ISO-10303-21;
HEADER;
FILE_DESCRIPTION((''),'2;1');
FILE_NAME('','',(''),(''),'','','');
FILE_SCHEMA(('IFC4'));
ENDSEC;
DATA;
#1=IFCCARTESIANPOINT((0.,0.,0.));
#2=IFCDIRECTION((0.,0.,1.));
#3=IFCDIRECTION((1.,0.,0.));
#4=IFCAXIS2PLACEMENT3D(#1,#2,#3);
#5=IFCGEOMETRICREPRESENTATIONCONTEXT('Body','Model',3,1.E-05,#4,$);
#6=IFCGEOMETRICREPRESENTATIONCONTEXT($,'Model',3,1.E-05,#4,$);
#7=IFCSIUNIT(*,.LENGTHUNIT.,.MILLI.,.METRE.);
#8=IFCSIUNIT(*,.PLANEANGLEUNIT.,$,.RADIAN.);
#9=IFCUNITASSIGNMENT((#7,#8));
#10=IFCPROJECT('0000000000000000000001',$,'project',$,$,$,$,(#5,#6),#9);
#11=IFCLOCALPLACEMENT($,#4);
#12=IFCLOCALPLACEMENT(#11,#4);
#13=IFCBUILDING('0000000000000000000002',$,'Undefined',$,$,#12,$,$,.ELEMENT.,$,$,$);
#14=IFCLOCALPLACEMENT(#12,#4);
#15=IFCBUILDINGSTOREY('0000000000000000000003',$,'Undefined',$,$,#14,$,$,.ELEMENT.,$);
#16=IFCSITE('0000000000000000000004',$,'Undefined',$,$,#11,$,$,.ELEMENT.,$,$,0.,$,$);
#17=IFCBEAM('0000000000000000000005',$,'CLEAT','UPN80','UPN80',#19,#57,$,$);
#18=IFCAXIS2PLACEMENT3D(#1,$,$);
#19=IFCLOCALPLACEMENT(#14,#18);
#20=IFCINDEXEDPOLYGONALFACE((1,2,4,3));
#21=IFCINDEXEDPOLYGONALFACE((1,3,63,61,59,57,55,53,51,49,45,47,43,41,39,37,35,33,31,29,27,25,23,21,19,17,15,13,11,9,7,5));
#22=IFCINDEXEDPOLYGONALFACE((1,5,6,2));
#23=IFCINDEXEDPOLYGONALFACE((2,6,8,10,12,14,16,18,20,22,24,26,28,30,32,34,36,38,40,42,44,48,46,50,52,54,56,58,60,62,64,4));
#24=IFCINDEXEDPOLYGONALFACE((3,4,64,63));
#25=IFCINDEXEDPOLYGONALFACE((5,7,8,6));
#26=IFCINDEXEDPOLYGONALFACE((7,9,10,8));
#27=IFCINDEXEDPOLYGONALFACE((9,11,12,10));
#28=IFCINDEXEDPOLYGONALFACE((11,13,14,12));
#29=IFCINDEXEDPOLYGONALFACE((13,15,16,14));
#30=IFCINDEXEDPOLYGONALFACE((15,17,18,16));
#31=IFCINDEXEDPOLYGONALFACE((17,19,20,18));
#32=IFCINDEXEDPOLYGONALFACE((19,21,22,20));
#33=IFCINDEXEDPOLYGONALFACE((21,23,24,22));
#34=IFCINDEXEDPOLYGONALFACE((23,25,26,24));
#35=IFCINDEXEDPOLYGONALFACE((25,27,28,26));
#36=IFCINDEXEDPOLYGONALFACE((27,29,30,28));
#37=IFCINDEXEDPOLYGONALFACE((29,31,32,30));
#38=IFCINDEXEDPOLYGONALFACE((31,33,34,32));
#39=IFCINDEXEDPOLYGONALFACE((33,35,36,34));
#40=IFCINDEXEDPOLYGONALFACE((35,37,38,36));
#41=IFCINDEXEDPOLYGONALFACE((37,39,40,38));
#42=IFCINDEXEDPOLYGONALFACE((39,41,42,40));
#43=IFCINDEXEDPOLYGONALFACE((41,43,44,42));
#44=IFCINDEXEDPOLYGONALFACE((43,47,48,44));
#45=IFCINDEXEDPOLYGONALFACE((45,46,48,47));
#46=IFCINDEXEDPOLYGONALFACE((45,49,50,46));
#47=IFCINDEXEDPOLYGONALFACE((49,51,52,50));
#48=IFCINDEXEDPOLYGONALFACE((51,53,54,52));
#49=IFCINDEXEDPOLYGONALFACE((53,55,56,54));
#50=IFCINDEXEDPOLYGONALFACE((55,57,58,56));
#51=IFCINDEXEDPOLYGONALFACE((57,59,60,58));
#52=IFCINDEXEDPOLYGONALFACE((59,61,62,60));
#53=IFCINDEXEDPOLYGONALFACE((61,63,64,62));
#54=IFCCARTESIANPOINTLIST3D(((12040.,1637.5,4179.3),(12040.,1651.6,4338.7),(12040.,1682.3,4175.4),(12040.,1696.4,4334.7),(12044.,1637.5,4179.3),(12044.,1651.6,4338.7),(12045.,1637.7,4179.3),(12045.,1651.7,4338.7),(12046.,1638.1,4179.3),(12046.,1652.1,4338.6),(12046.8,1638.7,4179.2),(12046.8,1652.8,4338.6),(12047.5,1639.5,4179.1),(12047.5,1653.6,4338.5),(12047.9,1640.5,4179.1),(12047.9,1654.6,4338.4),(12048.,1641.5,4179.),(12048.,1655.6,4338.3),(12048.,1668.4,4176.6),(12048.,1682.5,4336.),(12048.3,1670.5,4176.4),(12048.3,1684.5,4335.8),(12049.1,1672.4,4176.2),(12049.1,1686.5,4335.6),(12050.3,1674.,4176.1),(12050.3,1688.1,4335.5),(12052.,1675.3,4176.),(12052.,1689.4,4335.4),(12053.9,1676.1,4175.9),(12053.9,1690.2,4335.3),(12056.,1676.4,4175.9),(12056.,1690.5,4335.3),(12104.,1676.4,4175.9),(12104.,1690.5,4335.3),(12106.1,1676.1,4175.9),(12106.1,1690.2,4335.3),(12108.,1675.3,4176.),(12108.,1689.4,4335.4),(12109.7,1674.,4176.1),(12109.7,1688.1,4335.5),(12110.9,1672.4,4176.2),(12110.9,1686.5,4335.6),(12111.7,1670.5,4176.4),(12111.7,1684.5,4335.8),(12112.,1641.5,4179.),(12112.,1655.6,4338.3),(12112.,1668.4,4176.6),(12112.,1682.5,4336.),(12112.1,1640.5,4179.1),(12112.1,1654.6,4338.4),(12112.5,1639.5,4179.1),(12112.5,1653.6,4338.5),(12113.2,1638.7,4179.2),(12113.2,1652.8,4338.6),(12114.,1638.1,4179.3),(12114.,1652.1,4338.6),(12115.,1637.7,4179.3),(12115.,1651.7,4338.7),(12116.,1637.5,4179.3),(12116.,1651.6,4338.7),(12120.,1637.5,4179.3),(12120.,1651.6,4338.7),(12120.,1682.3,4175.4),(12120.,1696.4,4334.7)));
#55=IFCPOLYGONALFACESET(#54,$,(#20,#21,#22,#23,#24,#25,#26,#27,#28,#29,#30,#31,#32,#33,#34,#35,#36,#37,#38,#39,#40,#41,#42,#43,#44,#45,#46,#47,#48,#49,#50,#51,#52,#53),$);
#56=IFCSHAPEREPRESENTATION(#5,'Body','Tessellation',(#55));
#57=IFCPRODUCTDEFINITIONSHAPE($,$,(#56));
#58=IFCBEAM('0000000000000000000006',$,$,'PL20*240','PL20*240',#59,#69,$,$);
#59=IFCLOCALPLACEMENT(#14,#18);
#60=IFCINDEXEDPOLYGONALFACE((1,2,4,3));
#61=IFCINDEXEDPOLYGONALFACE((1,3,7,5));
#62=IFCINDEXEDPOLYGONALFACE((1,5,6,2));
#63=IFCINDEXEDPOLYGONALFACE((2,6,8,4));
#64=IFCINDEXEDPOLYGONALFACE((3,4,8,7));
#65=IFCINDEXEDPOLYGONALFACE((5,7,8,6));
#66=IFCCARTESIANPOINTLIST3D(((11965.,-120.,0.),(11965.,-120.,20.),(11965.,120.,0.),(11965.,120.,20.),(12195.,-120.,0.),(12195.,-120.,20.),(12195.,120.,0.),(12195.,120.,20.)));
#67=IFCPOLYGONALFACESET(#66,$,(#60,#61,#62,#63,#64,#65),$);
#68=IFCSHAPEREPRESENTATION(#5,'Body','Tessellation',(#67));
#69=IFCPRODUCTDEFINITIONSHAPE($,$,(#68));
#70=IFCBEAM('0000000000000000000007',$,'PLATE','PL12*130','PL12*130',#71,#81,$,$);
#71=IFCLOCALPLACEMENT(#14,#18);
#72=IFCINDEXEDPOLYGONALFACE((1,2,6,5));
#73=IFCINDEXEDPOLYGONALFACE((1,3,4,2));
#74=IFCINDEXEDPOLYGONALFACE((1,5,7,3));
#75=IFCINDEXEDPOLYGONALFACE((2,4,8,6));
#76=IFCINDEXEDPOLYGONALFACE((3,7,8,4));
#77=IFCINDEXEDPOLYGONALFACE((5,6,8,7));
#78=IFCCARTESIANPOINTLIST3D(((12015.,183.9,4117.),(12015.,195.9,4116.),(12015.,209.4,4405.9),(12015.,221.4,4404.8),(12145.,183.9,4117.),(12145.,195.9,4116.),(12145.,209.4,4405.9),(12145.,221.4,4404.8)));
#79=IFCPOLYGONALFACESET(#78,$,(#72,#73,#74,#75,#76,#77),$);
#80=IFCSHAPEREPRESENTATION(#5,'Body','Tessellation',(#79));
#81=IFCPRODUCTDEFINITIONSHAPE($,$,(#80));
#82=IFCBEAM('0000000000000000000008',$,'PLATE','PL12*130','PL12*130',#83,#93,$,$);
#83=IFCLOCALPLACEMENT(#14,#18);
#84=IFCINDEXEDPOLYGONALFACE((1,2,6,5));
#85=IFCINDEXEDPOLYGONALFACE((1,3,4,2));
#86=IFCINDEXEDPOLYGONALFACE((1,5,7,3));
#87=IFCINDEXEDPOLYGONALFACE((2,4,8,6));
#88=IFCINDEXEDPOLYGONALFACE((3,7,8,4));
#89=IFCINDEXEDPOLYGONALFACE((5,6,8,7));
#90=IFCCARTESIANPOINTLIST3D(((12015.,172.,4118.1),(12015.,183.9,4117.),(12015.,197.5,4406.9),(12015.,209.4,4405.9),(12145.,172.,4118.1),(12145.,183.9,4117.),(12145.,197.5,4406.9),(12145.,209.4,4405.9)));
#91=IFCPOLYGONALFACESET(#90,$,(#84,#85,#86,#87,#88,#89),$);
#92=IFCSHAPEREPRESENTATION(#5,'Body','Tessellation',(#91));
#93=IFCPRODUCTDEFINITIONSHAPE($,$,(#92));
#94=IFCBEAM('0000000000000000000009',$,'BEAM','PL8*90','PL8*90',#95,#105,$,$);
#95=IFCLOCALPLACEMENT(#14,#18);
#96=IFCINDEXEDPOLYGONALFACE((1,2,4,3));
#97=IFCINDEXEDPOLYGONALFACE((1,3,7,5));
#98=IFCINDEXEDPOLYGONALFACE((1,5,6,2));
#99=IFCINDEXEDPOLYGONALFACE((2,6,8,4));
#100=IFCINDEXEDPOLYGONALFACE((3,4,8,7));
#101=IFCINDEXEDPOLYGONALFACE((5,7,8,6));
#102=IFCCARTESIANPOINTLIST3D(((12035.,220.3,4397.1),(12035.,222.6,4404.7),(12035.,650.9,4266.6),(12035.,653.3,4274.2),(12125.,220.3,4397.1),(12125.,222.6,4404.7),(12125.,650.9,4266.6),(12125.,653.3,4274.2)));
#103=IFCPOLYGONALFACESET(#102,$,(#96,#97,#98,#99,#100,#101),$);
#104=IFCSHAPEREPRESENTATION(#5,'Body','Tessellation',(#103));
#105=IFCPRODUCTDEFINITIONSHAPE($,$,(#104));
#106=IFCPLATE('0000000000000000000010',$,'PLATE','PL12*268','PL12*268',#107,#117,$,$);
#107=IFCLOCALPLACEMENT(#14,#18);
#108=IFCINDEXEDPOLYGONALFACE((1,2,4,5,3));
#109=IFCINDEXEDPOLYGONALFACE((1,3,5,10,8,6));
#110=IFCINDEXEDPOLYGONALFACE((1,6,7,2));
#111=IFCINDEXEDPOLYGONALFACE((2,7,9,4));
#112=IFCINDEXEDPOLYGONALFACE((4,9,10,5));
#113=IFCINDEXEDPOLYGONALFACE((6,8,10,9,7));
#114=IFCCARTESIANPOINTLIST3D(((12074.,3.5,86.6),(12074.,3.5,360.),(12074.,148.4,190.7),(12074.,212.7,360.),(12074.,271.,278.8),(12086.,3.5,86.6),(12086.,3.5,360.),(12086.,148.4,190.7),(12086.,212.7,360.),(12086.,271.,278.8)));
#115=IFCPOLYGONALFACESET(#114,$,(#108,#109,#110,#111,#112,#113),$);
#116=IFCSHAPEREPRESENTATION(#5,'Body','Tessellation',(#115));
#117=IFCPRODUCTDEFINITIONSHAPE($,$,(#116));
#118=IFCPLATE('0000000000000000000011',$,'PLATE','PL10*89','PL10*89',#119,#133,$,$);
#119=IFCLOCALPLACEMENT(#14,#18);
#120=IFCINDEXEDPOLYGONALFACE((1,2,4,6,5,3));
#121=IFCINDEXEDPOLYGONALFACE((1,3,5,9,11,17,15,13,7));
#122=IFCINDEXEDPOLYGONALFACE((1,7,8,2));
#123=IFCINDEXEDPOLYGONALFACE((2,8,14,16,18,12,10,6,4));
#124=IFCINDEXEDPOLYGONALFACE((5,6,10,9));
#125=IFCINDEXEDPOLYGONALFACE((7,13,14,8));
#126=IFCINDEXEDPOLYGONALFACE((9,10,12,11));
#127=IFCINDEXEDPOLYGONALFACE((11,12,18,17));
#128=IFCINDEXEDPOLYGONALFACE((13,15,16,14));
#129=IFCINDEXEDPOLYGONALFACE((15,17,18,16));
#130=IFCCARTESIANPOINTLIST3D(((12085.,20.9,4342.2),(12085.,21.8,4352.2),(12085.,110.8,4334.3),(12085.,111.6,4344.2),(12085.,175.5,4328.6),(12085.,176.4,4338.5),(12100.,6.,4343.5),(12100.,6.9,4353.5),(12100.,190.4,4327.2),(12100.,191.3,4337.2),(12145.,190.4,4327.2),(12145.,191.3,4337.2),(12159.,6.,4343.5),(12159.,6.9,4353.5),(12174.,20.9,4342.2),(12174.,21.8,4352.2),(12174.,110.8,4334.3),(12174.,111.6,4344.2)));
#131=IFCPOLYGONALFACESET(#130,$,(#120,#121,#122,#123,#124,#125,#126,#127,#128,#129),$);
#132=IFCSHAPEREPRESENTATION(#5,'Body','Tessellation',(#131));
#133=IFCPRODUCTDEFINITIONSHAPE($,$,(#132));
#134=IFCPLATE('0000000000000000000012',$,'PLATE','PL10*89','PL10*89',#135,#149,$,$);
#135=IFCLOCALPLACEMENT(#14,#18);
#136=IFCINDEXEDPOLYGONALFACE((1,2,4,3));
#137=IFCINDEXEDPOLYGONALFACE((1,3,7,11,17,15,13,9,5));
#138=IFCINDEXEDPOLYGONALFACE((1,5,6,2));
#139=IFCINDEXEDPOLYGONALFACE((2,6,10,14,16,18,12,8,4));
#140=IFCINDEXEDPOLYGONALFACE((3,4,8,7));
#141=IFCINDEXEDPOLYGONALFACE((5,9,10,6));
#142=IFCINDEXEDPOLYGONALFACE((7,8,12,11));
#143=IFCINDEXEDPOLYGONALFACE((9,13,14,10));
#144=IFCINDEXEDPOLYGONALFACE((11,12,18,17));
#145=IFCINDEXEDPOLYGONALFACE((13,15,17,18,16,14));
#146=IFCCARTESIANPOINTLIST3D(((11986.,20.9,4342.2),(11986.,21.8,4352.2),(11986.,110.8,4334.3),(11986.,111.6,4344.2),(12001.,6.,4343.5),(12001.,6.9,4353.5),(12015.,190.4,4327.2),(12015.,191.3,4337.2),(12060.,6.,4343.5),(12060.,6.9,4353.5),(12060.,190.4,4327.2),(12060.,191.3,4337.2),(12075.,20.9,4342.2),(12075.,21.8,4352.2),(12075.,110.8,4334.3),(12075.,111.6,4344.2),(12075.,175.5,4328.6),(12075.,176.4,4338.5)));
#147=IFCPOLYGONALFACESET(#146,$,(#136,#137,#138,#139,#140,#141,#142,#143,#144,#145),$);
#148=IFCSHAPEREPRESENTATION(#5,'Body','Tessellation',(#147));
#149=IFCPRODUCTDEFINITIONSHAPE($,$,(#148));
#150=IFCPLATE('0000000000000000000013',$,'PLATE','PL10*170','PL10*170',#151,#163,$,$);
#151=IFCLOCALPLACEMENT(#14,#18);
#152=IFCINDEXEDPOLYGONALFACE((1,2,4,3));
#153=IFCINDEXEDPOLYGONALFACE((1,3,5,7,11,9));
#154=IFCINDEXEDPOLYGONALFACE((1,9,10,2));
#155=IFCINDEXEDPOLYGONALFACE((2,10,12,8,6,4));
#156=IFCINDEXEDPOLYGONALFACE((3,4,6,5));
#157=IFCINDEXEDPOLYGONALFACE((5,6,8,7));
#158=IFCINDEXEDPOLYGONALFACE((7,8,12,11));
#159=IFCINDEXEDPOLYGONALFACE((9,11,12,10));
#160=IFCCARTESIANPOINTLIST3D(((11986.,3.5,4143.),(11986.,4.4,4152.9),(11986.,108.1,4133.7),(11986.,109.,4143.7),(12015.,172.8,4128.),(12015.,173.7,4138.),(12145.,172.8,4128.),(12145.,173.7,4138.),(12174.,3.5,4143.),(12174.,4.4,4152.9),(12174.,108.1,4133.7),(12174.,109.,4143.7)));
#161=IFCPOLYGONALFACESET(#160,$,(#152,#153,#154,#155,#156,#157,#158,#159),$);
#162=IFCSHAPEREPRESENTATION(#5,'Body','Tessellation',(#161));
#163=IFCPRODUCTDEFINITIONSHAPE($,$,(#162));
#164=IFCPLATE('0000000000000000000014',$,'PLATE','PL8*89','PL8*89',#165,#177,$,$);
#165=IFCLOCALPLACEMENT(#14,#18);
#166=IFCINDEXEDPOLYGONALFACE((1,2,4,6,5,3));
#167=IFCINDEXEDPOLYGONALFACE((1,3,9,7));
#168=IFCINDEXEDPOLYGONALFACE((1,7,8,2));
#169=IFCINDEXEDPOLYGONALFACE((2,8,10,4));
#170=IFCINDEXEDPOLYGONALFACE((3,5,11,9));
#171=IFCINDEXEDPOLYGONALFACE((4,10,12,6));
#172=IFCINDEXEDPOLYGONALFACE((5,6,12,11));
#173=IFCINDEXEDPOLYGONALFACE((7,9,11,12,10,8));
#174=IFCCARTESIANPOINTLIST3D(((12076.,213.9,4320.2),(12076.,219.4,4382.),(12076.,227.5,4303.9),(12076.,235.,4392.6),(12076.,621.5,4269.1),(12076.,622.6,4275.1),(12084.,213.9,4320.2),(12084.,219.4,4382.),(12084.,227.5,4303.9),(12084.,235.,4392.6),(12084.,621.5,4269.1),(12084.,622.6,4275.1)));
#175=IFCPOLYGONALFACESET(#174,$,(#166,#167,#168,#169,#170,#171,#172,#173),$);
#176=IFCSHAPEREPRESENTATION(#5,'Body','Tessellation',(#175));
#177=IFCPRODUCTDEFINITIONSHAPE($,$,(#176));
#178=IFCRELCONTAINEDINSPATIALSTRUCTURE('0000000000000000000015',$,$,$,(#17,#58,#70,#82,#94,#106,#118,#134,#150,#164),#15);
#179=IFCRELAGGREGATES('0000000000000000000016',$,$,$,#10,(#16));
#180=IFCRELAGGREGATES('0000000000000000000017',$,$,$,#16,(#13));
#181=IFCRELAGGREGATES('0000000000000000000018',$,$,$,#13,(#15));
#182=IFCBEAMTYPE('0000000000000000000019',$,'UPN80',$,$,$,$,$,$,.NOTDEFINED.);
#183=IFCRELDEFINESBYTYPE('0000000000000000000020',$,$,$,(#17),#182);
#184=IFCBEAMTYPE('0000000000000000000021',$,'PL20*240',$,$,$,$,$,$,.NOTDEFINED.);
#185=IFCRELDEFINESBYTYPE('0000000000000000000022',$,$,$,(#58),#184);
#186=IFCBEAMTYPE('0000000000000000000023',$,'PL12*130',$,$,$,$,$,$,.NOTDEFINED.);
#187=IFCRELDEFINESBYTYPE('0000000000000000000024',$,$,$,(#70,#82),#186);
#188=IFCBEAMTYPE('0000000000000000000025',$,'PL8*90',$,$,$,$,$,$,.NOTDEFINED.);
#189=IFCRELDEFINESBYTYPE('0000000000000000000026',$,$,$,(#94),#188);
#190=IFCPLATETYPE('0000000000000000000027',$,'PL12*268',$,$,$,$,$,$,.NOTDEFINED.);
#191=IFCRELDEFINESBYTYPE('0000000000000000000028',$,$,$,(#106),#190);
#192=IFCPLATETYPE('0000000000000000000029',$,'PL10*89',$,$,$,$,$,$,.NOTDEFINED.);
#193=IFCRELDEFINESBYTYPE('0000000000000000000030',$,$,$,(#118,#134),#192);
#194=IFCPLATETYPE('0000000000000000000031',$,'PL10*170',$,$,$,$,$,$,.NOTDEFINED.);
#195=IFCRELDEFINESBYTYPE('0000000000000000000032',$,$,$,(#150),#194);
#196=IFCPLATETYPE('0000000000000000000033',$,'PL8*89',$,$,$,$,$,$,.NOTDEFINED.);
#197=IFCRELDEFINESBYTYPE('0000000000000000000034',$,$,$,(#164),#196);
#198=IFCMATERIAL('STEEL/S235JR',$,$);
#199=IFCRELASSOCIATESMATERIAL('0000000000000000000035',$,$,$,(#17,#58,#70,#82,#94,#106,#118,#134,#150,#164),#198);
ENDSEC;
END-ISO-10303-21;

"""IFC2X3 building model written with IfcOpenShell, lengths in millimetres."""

from ifc_helpers import new_model, si_unit, frame, origin_with_axes, origin_2d_with_axis, place, context, project, spatial, polyline, rectangle, u_section, outline, extrude, material, type_object, element, save


model = new_model("IFC2X3")

# Units and contexts
model_context_1 = context("Model", 3, precision=1e-05, world=origin_with_axes(), identifier="Body")
model_context_2 = context("Model", 3, precision=1e-05, world=origin_with_axes())
ifc_project = project(units=[si_unit("LENGTHUNIT", "METRE", prefix="MILLI"), si_unit("PLANEANGLEUNIT", "RADIAN")], contexts=[model_context_1, model_context_2])

# Site, building, storey
site_placement = place(None, origin_with_axes())
site = spatial("IfcSite", under=ifc_project, at=site_placement, Name="Undefined", CompositionType="ELEMENT", RefElevation=0.0)
building_placement = place(site_placement, origin_with_axes())
building = spatial("IfcBuilding", under=site, at=building_placement, Name="Undefined", CompositionType="ELEMENT")
storey_placement = place(building_placement, origin_with_axes())
storey = spatial("IfcBuildingStorey", under=building, at=storey_placement, Name="Undefined", CompositionType="ELEMENT")

# Shared definitions
ifc_material = material(Name="STEEL/S235JR")

# Beams
beam_type_1 = type_object("IfcBeamType", Name="UPN80", PredefinedType="NOTDEFINED")
beam_1_placement = place(storey_placement, frame((12080.0, 1659.9, 4177.3), z_axis=(-1.0, 0.0, 0.0), x_axis=(0.0, 0.08801, 0.99612)))
element("IfcBeam", 1, at=beam_1_placement, inside=storey, type_object=beam_type_1, material=ifc_material, Name="CLEAT", Description="UPN80", ObjectType="UPN80", context=model_context_1, shape_type="SweptSolid", body=[
    extrude(u_section(Depth=80.0, FlangeWidth=45.0, WebThickness=6.0, FlangeThickness=8.0, FilletRadius=8.0, EdgeRadius=4.0, at=origin_2d_with_axis()), frame((160.0, 0.0, 0.0), z_axis=(-1.0, 0.0, 0.0), x_axis=(0.0, -1.0, 0.0)), (0.0, 0.0, 1.0), 160.0),
])
beam_type_2 = type_object("IfcBeamType", Name="PL20*240", PredefinedType="NOTDEFINED")
beam_2_placement = place(storey_placement, frame((12195.0, 0.0, 10.0), z_axis=(0.0, -1.0, 0.0), x_axis=(-1.0, 0.0, 0.0)))
element("IfcBeam", 2, at=beam_2_placement, inside=storey, type_object=beam_type_2, material=ifc_material, Description="PL20*240", ObjectType="PL20*240", context=model_context_1, shape_type="SweptSolid", body=[
    extrude(rectangle(XDim=20.0, YDim=240.0, at=origin_2d_with_axis()), frame((230.0, 0.0, 0.0), z_axis=(-1.0, 0.0, 0.0), x_axis=(0.0, -1.0, 0.0)), (0.0, 0.0, 1.0), 230.0),
])
beam_type_3 = type_object("IfcBeamType", Name="PL12*130", PredefinedType="NOTDEFINED")
beam_3_placement = place(storey_placement, frame((12080.0, 189.9, 4116.5), z_axis=(1.0, 0.0, 0.0), x_axis=(0.0, 0.08801, 0.99612)))
element("IfcBeam", 3, at=beam_3_placement, inside=storey, type_object=beam_type_3, material=ifc_material, Name="PLATE", Description="PL12*130", ObjectType="PL12*130", context=model_context_1, shape_type="SweptSolid", body=[
    extrude(rectangle(XDim=12.0, YDim=130.0, at=origin_2d_with_axis()), frame((290.0, 0.0, 0.0), z_axis=(-1.0, 0.0, 0.0), x_axis=(0.0, -1.0, 0.0)), (0.0, 0.0, 1.0), 290.0),
])
beam_4_placement = place(storey_placement, frame((12080.0, 177.9, 4117.5), z_axis=(1.0, 0.0, 0.0), x_axis=(0.0, 0.08801, 0.99612)))
element("IfcBeam", 4, at=beam_4_placement, inside=storey, type_object=beam_type_3, material=ifc_material, Name="PLATE", Description="PL12*130", ObjectType="PL12*130", context=model_context_1, shape_type="SweptSolid", body=[
    extrude(rectangle(XDim=12.0, YDim=130.0, at=origin_2d_with_axis()), frame((290.0, 0.0, 0.0), z_axis=(-1.0, 0.0, 0.0), x_axis=(0.0, -1.0, 0.0)), (0.0, 0.0, 1.0), 290.0),
])
beam_type_4 = type_object("IfcBeamType", Name="PL8*90", PredefinedType="NOTDEFINED")
beam_5_placement = place(storey_placement, frame((12080.0, 221.4, 4400.9), z_axis=(1.0, 0.0, 0.0), x_axis=(0.0, 0.957026, -0.290002)))
element("IfcBeam", 5, at=beam_5_placement, inside=storey, type_object=beam_type_4, material=ifc_material, Name="BEAM", Description="PL8*90", ObjectType="PL8*90", context=model_context_1, shape_type="SweptSolid", body=[
    extrude(rectangle(XDim=8.0, YDim=90.0, at=origin_2d_with_axis()), frame((450.0, 0.0, 0.0), z_axis=(-1.0, 0.0, 0.0), x_axis=(0.0, -1.0, 0.0)), (0.0, 0.0, 1.0), 450.0),
])

# Plates
plate_type_1 = type_object("IfcPlateType", Name="PL12*268", PredefinedType="NOTDEFINED")
plate_1_placement = place(storey_placement, frame((12080.0, 3.5, 86.6), z_axis=(-1.0, 0.0, 0.0), x_axis=(0.0, 0.0, 1.0)))
element("IfcPlate", 6, at=plate_1_placement, inside=storey, type_object=plate_type_1, material=ifc_material, Name="PLATE", Description="PL12*268", ObjectType="PL12*268", context=model_context_1, shape_type="SweptSolid", body=[
    extrude(outline(polyline([(0.0, 0.0), (273.4, 0.0), (273.4, 209.2), (192.2, 267.5), (104.1, 144.9), (0.0, 0.0)])), frame((0.0, 0.0, -6.0), z_axis=(0.0, 0.0, 1.0), x_axis=(1.0, 0.0, 0.0)), (0.0, 0.0, 1.0), 12.0),
])
plate_type_2 = type_object("IfcPlateType", Name="PL10*89", PredefinedType="NOTDEFINED")
for number, where, z_axis, x_axis, name in (
    (7, (12085.0, 190.9, 4332.2), (0.0, 0.08801, 0.99612), (0.0, -0.99612, 0.08801), "PLATE"),
    (8, (12075.0, 190.9, 4332.2), (0.0, -0.08801, -0.99612), (0.0, -0.99612, 0.08801), "PLATE"),
):
    element("IfcPlate", number, at=place(storey_placement, frame(where, z_axis=z_axis, x_axis=x_axis)), inside=storey, type_object=plate_type_2, material=ifc_material, Name=name, Description="PL10*89", ObjectType="PL10*89", context=model_context_1, shape_type="SweptSolid", body=[
        extrude(outline(polyline([(0.0, 15.0), (15.0, 0.0), (80.0, 0.0), (170.2, 0.0), (185.2, 15.0), (185.2, 74.0), (170.2, 89.0), (80.0, 89.0), (0.0, 60.0), (0.0, 15.0)])), frame((0.0, 0.0, -5.0), z_axis=(0.0, 0.0, 1.0), x_axis=(1.0, 0.0, 0.0)), (0.0, 0.0, 1.0), 10.0),
    ])
plate_type_3 = type_object("IfcPlateType", Name="PL10*170", PredefinedType="NOTDEFINED")
plate_2_placement = place(storey_placement, frame((12145.0, 173.3, 4133.0), z_axis=(0.0, -0.08801, -0.99612), x_axis=(0.407441, -0.909688, 0.080373)))
element("IfcPlate", 9, at=plate_2_placement, inside=storey, type_object=plate_type_3, material=ifc_material, Name="PLATE", Description="PL10*170", ObjectType="PL10*170", context=model_context_1, shape_type="SweptSolid", body=[
    extrude(outline(polyline([(0.0, 0.0), (71.2, 0.0), (167.1, 42.8), (90.5, 214.5), (-5.4, 171.7), (-53.0, 118.7), (0.0, 0.0)])), frame((0.0, 0.0, -5.0), z_axis=(0.0, 0.0, 1.0), x_axis=(1.0, 0.0, 0.0)), (0.0, 0.0, 1.0), 10.0),
])
plate_type_4 = type_object("IfcPlateType", Name="PL8*89", PredefinedType="NOTDEFINED")
plate_3_placement = place(storey_placement, frame((12080.0, 212.6, 4305.2), z_axis=(-1.0, 0.0, 0.0), x_axis=(0.0, 0.08801, 0.99612)))
element("IfcPlate", 10, at=plate_3_placement, inside=storey, type_object=plate_type_4, material=ifc_material, Name="PLATE", Description="PL8*89", ObjectType="PL8*89", context=model_context_1, shape_type="SweptSolid", body=[
    extrude(outline(polyline([(0.0, 15.0), (15.0, 0.0), (77.1, 0.0), (89.0, 14.7), (6.1, 411.1), (0.0, 410.5), (0.0, 15.0)])), frame((0.0, 0.0, -4.0), z_axis=(0.0, 0.0, 1.0), x_axis=(1.0, 0.0, 0.0)), (0.0, 0.0, 1.0), 8.0),
])

save(model, "model.ifc")
